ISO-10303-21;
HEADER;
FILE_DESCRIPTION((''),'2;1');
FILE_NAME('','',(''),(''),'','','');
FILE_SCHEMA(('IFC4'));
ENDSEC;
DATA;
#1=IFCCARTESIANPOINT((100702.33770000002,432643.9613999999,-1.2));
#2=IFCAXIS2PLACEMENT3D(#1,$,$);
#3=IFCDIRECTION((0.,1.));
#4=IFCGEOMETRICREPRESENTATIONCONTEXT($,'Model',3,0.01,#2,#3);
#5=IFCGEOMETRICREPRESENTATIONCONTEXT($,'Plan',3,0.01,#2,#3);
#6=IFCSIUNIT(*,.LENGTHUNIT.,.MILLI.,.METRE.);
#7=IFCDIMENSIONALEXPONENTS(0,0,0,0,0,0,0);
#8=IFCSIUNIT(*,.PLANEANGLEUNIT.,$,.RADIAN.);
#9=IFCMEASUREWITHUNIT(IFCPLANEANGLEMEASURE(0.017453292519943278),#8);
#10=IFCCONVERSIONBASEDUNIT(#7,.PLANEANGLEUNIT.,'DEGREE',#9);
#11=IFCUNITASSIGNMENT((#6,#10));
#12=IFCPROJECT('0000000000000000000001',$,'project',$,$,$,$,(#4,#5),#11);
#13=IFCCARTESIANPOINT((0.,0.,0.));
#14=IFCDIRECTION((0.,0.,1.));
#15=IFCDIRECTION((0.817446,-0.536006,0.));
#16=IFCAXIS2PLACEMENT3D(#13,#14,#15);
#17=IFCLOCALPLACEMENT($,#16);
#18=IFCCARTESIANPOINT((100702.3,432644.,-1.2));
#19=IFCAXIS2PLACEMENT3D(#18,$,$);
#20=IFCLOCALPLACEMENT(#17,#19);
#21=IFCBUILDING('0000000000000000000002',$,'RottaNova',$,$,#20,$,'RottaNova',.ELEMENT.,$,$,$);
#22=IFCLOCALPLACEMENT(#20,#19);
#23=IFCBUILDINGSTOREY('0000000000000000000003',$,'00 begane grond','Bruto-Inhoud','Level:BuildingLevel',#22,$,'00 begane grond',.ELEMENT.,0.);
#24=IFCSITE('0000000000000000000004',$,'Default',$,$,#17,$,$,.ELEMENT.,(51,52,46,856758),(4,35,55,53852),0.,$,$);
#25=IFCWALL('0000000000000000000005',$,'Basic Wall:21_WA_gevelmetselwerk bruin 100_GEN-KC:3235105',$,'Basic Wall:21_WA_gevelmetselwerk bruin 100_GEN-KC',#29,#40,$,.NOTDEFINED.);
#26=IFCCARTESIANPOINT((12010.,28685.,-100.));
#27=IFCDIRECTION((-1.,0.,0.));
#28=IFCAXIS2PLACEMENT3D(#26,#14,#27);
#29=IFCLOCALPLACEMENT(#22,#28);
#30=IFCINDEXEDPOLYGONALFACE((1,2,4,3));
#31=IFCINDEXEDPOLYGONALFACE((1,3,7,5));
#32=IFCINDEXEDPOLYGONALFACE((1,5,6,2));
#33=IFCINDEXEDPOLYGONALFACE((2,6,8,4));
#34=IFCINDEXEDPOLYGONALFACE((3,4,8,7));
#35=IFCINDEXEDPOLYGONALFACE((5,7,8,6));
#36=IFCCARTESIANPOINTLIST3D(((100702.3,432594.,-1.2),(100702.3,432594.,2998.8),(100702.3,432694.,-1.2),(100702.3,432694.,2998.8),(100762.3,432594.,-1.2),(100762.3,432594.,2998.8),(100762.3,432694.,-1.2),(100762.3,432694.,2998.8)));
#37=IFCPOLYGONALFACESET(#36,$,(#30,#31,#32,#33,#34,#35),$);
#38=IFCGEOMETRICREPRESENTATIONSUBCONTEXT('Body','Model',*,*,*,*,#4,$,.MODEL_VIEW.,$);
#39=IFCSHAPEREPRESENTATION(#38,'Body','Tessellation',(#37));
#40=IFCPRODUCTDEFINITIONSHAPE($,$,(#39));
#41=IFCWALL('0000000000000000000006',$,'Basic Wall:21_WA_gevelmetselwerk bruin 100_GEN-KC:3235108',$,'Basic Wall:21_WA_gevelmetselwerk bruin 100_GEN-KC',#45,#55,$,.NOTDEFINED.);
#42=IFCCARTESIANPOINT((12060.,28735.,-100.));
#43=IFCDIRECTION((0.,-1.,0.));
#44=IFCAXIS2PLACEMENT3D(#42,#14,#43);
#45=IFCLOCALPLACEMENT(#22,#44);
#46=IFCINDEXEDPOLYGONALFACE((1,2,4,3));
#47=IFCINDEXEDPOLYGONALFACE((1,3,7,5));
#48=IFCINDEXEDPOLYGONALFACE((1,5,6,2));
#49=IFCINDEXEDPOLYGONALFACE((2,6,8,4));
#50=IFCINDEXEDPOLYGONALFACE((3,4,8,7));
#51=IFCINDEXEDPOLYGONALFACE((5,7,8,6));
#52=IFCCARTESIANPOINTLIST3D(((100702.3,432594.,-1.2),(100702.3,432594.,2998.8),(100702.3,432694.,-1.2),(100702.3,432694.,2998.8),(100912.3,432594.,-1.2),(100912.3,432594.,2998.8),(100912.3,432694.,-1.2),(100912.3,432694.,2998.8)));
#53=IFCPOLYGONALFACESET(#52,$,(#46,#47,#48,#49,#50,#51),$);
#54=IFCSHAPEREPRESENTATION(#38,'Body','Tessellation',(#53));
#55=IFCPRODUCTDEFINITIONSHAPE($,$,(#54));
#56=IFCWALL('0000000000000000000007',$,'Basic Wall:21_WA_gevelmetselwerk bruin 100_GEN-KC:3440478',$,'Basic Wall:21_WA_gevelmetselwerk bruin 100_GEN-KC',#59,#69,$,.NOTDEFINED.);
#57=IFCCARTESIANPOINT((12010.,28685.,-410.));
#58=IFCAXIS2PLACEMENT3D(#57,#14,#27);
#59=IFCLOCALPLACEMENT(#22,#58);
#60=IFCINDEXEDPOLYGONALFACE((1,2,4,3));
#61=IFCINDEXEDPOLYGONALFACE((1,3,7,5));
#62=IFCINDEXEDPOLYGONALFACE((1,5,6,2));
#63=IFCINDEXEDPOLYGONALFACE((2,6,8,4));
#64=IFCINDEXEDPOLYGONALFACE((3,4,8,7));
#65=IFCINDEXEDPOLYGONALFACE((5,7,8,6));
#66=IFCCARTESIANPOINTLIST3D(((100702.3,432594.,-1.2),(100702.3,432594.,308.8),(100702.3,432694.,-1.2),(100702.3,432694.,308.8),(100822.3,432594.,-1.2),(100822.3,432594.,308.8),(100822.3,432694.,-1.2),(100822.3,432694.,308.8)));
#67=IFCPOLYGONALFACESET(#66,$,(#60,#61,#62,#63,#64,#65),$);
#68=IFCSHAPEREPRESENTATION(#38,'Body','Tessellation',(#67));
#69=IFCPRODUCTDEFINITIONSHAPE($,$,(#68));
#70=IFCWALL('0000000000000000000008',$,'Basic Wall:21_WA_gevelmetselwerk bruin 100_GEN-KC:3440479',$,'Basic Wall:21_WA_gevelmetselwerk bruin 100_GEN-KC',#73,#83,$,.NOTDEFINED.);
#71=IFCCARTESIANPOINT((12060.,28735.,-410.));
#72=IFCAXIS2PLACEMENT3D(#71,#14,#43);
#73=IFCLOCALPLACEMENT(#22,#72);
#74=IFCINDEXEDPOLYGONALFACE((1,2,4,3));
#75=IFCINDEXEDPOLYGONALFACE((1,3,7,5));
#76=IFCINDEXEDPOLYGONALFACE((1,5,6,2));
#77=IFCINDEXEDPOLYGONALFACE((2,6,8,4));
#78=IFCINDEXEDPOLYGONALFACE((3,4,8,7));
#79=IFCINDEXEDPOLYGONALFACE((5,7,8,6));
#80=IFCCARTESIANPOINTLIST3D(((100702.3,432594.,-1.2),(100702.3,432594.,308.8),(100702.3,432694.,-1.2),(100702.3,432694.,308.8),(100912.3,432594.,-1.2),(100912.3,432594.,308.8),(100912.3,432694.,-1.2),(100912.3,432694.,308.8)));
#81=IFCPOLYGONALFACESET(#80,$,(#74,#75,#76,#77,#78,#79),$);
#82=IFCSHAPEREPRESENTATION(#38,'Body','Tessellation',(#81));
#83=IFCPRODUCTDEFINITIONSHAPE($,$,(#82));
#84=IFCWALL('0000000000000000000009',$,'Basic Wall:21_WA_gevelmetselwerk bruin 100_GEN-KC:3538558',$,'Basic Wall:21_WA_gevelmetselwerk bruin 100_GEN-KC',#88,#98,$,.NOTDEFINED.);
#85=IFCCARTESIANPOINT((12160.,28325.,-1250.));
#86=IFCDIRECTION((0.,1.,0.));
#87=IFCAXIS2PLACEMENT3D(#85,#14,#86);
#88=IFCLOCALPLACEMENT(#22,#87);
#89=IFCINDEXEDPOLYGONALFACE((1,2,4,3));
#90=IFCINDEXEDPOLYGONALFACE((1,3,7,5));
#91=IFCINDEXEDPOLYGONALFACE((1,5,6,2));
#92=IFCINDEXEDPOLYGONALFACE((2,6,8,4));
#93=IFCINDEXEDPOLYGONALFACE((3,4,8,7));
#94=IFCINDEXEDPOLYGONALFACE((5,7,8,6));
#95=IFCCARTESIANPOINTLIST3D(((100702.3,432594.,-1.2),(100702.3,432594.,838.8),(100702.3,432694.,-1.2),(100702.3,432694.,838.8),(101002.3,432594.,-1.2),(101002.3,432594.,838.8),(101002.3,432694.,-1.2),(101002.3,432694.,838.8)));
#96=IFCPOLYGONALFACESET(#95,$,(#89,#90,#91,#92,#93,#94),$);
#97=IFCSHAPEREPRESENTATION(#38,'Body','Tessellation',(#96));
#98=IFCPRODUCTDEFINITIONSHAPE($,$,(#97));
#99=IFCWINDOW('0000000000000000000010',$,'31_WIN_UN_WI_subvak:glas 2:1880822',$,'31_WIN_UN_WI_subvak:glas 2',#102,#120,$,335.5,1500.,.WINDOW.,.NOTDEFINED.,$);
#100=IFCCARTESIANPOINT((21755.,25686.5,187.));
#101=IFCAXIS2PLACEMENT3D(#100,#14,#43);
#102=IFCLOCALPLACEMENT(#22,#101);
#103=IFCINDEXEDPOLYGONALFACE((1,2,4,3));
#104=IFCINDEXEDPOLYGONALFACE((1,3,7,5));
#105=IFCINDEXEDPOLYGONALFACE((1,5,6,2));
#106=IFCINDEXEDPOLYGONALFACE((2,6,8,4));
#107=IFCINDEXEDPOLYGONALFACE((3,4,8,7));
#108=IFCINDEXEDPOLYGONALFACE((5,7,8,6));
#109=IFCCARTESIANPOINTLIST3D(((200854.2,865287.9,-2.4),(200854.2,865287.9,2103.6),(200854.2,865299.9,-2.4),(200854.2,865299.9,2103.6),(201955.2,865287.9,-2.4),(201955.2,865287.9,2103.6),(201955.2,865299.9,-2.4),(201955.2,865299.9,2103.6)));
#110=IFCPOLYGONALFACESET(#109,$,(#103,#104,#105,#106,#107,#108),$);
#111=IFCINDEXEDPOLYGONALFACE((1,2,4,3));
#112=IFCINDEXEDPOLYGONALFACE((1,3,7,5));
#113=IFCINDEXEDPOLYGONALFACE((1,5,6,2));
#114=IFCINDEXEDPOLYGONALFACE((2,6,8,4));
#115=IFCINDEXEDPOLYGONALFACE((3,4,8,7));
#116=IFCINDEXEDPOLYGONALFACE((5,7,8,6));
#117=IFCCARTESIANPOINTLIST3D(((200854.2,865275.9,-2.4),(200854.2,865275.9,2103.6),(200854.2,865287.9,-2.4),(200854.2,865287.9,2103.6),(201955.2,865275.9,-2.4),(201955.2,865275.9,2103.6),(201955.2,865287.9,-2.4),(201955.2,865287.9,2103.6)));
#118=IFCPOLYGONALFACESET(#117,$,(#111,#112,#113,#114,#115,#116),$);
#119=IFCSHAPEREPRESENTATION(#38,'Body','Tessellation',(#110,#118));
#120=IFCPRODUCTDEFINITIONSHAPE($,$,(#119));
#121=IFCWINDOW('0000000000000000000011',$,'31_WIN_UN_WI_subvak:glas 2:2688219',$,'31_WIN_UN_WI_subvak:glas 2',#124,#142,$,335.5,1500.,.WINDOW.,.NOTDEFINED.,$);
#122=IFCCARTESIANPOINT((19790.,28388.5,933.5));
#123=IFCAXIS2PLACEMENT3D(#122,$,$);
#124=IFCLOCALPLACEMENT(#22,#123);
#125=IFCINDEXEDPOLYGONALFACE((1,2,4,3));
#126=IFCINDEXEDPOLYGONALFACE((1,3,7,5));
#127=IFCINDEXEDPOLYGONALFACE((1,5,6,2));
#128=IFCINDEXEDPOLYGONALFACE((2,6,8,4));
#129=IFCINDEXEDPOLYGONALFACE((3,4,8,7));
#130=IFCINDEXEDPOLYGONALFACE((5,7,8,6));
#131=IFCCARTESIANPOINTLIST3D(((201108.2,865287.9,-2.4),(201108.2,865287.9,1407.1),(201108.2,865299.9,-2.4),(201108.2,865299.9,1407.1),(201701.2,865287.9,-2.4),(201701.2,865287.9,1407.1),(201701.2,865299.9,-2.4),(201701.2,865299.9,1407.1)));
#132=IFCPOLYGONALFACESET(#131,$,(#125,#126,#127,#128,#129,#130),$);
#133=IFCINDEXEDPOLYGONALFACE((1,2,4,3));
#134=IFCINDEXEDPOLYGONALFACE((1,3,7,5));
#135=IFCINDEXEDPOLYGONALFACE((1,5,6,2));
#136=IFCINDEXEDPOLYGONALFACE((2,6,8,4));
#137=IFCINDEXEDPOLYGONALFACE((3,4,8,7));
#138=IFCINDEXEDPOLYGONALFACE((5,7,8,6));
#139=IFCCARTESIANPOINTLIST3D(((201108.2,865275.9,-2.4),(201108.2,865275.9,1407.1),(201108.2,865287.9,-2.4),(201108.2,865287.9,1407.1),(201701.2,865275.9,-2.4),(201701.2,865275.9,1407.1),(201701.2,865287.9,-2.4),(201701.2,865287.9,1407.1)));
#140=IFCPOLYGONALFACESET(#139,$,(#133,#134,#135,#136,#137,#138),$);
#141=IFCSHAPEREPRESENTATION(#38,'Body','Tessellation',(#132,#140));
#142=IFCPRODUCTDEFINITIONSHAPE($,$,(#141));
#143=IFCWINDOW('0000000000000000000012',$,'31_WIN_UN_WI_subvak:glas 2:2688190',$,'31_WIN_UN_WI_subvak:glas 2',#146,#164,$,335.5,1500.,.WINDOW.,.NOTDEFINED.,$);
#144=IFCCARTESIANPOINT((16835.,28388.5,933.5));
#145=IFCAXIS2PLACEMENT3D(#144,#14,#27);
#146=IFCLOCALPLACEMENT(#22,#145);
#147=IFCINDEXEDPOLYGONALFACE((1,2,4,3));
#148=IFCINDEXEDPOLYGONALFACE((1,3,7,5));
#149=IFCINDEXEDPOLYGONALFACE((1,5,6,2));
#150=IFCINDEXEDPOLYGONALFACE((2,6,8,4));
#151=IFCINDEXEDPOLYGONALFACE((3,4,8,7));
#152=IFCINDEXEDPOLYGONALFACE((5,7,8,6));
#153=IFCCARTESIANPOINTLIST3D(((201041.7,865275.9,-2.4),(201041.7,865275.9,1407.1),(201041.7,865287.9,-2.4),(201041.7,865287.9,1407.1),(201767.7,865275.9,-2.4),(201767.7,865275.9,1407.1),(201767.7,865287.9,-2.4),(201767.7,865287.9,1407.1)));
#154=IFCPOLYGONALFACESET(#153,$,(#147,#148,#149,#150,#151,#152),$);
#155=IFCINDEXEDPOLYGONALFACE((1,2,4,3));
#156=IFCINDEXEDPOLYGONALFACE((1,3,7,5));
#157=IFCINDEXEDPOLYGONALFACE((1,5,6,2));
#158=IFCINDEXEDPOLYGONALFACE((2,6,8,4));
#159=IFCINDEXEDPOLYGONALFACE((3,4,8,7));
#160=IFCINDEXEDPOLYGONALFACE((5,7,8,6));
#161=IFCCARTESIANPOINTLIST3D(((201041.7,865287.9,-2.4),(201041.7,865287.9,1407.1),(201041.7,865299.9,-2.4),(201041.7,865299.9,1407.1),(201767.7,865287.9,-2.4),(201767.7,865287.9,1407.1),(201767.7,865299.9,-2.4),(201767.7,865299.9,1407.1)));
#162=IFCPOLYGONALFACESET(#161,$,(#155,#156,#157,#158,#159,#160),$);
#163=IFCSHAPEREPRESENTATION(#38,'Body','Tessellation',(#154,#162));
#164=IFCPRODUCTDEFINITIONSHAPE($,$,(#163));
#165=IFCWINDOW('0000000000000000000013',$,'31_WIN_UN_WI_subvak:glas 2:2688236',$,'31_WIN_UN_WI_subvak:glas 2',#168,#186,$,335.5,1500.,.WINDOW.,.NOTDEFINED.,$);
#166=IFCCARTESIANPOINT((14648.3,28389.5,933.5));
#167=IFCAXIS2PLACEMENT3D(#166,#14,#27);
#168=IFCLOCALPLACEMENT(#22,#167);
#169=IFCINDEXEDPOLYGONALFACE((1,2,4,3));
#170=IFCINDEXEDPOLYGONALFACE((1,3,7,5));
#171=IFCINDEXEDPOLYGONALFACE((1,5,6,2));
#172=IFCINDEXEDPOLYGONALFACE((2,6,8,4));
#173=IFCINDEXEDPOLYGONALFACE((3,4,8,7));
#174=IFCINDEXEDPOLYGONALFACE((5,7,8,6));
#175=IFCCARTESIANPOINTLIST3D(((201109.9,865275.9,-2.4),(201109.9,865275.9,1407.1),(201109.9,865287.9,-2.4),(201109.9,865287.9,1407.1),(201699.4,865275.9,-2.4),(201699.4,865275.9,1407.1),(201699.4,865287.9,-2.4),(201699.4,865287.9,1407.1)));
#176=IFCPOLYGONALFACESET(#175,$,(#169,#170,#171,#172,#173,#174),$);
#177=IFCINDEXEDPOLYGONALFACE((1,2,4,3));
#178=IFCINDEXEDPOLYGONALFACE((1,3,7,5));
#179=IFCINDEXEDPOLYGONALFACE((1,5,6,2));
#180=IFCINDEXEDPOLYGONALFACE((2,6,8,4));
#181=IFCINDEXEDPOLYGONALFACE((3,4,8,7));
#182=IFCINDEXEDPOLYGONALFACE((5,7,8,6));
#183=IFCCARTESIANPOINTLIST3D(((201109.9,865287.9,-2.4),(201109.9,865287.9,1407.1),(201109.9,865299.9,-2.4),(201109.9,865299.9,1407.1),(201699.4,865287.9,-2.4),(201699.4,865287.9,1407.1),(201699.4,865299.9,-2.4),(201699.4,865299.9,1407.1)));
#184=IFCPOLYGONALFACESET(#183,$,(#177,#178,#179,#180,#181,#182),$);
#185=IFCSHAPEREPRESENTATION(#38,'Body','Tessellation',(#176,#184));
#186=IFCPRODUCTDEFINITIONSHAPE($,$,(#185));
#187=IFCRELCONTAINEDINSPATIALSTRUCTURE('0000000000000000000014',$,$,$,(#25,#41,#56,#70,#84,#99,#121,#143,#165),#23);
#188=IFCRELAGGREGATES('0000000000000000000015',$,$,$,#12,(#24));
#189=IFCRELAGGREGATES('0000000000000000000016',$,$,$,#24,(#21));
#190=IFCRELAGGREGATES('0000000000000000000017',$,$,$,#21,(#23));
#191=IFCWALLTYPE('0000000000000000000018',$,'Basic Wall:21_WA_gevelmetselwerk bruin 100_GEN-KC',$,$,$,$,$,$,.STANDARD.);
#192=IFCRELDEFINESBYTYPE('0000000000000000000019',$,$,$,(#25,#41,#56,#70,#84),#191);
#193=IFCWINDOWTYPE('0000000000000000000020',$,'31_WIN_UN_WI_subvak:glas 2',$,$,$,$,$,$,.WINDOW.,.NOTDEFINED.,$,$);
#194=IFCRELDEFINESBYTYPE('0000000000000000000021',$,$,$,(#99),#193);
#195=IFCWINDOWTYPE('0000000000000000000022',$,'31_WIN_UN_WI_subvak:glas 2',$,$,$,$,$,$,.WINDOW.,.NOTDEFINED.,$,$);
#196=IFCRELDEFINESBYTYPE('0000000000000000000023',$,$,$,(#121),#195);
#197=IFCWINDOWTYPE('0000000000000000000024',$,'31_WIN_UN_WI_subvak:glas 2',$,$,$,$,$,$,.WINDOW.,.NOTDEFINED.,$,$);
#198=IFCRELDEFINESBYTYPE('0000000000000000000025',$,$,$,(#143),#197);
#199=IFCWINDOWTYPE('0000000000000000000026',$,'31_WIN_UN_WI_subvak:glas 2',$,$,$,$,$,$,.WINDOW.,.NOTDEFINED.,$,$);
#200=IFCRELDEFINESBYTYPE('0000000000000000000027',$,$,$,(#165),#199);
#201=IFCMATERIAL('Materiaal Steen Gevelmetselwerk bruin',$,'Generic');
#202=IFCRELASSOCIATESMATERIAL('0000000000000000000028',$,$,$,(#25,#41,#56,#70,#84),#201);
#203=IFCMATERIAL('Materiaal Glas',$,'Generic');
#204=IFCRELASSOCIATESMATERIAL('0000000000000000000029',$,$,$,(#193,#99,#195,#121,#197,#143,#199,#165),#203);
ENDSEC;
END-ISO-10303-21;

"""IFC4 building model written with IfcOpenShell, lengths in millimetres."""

from ifc_helpers import new_model, entity, si_unit, converted_unit, direction, frame, place, context, subcontext, project, spatial, indexed_curve, outline, extrude, source, transform, mapped, material, type_object, type_shapes, element, save


model = new_model("IFC4")

# Units and contexts
model_context = context("Model", 3, precision=0.01, world=frame((100702.33770000002, 432643.9613999999, -1.2)), true_north=direction((0.0, 1.0)))
plan_context = context("Plan", 3, precision=0.01, world=frame((100702.33770000002, 432643.9613999999, -1.2)), true_north=direction((0.0, 1.0)))
body_context = subcontext(model_context, "Body", "Model", "MODEL_VIEW")
ifc_project = project(units=[si_unit("LENGTHUNIT", "METRE", prefix="MILLI"), converted_unit("PLANEANGLEUNIT", "DEGREE", entity("IfcPlaneAngleMeasure", 0.017453292519943278), si_unit("PLANEANGLEUNIT", "RADIAN"), dimensions=[0, 0, 0, 0, 0, 0, 0])], contexts=[model_context, plan_context])

# Site, building, storey
site_placement = place(None, frame((0.0, 0.0, 0.0), z_axis=(0.0, 0.0, 1.0), x_axis=(0.817446, -0.536006, 0.0)))
site = spatial("IfcSite", under=ifc_project, at=site_placement, Name="Default", CompositionType="ELEMENT", RefLatitude=(51, 52, 46, 856758), RefLongitude=(4, 35, 55, 53852), RefElevation=0.0)
building_placement = place(site_placement, frame((100702.3, 432644.0, -1.2)))
building = spatial("IfcBuilding", under=site, at=building_placement, Name="RottaNova", LongName="RottaNova", CompositionType="ELEMENT")
storey_placement = place(building_placement, frame((100702.3, 432644.0, -1.2)))
storey = spatial("IfcBuildingStorey", under=building, at=storey_placement, Name="00 begane grond", Description="Bruto-Inhoud", ObjectType="Level:BuildingLevel", LongName="00 begane grond", CompositionType="ELEMENT", Elevation=0.0)

# Walls
ifc_material_1 = material(Name="Materiaal Steen Gevelmetselwerk bruin", Category="Generic")
wall_type_1 = type_object("IfcWallType", Name="Basic Wall:21_WA_gevelmetselwerk bruin 100_GEN-KC", PredefinedType="STANDARD")
wall_1_placement = place(storey_placement, frame((12010.0, 28685.0, -100.0), z_axis=(0.0, 0.0, 1.0), x_axis=(-1.0, 0.0, 0.0)))
element("IfcWall", 1, at=wall_1_placement, inside=storey, type_object=wall_type_1, material=ifc_material_1, Name="Basic Wall:21_WA_gevelmetselwerk bruin 100_GEN-KC:3235105", ObjectType="Basic Wall:21_WA_gevelmetselwerk bruin 100_GEN-KC", PredefinedType="NOTDEFINED", context=body_context, shape_type="SweptSolid", body=[
    extrude(outline(indexed_curve([(60.0, 50.0), (0.0, 50.0), (0.0, -50.0), (60.0, -50.0), (60.0, 50.0)], self_intersect=False)), frame((100702.3, 432644.0, -1.2)), (0.0, 0.0, 1.0), 3000.0),
])
wall_2_placement = place(storey_placement, frame((12060.0, 28735.0, -100.0), z_axis=(0.0, 0.0, 1.0), x_axis=(0.0, -1.0, 0.0)))
element("IfcWall", 2, at=wall_2_placement, inside=storey, type_object=wall_type_1, material=ifc_material_1, Name="Basic Wall:21_WA_gevelmetselwerk bruin 100_GEN-KC:3235108", ObjectType="Basic Wall:21_WA_gevelmetselwerk bruin 100_GEN-KC", PredefinedType="NOTDEFINED", context=body_context, shape_type="SweptSolid", body=[
    extrude(outline(indexed_curve([(210.0, 50.0), (0.0, 50.0), (0.0, -50.0), (210.0, -50.0), (210.0, 50.0)], self_intersect=False)), frame((100702.3, 432644.0, -1.2)), (0.0, 0.0, 1.0), 3000.0),
])
wall_3_placement = place(storey_placement, frame((12010.0, 28685.0, -410.0), z_axis=(0.0, 0.0, 1.0), x_axis=(-1.0, 0.0, 0.0)))
element("IfcWall", 3, at=wall_3_placement, inside=storey, type_object=wall_type_1, material=ifc_material_1, Name="Basic Wall:21_WA_gevelmetselwerk bruin 100_GEN-KC:3440478", ObjectType="Basic Wall:21_WA_gevelmetselwerk bruin 100_GEN-KC", PredefinedType="NOTDEFINED", context=body_context, shape_type="SweptSolid", body=[
    extrude(outline(indexed_curve([(120.0, 50.0), (0.0, 50.0), (0.0, -50.0), (120.0, -50.0), (120.0, 50.0)], self_intersect=False)), frame((100702.3, 432644.0, -1.2)), (0.0, 0.0, 1.0), 310.0),
])
wall_4_placement = place(storey_placement, frame((12060.0, 28735.0, -410.0), z_axis=(0.0, 0.0, 1.0), x_axis=(0.0, -1.0, 0.0)))
element("IfcWall", 4, at=wall_4_placement, inside=storey, type_object=wall_type_1, material=ifc_material_1, Name="Basic Wall:21_WA_gevelmetselwerk bruin 100_GEN-KC:3440479", ObjectType="Basic Wall:21_WA_gevelmetselwerk bruin 100_GEN-KC", PredefinedType="NOTDEFINED", context=body_context, shape_type="SweptSolid", body=[
    extrude(outline(indexed_curve([(210.0, 50.0), (0.0, 50.0), (0.0, -50.0), (210.0, -50.0), (210.0, 50.0)], self_intersect=False)), frame((100702.3, 432644.0, -1.2)), (0.0, 0.0, 1.0), 310.0),
])
wall_5_placement = place(storey_placement, frame((12160.0, 28325.0, -1250.0), z_axis=(0.0, 0.0, 1.0), x_axis=(0.0, 1.0, 0.0)))
element("IfcWall", 5, at=wall_5_placement, inside=storey, type_object=wall_type_1, material=ifc_material_1, Name="Basic Wall:21_WA_gevelmetselwerk bruin 100_GEN-KC:3538558", ObjectType="Basic Wall:21_WA_gevelmetselwerk bruin 100_GEN-KC", PredefinedType="NOTDEFINED", context=body_context, shape_type="SweptSolid", body=[
    extrude(outline(indexed_curve([(300.0, 50.0), (0.0, 50.0), (0.0, -50.0), (300.0, -50.0), (300.0, 50.0)], self_intersect=False)), frame((100702.3, 432644.0, -1.2)), (0.0, 0.0, 1.0), 840.0),
])

# Windows
ifc_material_2 = material(Name="Materiaal Glas", Category="Generic")
window_type_1 = type_object("IfcWindowType", Name="31_WIN_UN_WI_subvak:glas 2", PartitioningType="NOTDEFINED", PredefinedType="WINDOW", material=ifc_material_2)
shared_shape_1 = source(frame((100702.3, 432644.0, -1.2)), body_context, "Body", "SweptSolid", [
    extrude(outline(indexed_curve([(-6.0, -550.5), (6.0, -550.5), (6.0, 550.5), (-6.0, 550.5), (-6.0, -550.5)], self_intersect=False)), frame((0.0, 6.0, 0.0), z_axis=(0.0, 0.0, 1.0), x_axis=(0.0, -1.0, 0.0)), (0.0, 0.0, 1.0), 2106.0),
    extrude(outline(indexed_curve([(-6.0, -550.5), (6.0, -550.5), (6.0, 550.5), (-6.0, 550.5), (-6.0, -550.5)], self_intersect=False)), frame((0.0, -6.0, 0.0), z_axis=(0.0, 0.0, 1.0), x_axis=(0.0, -1.0, 0.0)), (0.0, 0.0, 1.0), 2106.0),
])
type_shapes(window_type_1, [shared_shape_1])
window_1_placement = place(storey_placement, frame((21755.0, 25686.5, 187.0), z_axis=(0.0, 0.0, 1.0), x_axis=(0.0, -1.0, 0.0)))
element("IfcWindow", 6, at=window_1_placement, inside=storey, type_object=window_type_1, material=ifc_material_2, Name="31_WIN_UN_WI_subvak:glas 2:1880822", ObjectType="31_WIN_UN_WI_subvak:glas 2", OverallHeight=335.5, OverallWidth=1500.0, PartitioningType="NOTDEFINED", PredefinedType="WINDOW", context=body_context, shape_type="MappedRepresentation", body=[
    mapped(shared_shape_1, transform((100702.3, 432644.0, -1.2), scale=1.0)),
])
window_type_2 = type_object("IfcWindowType", Name="31_WIN_UN_WI_subvak:glas 2", PartitioningType="NOTDEFINED", PredefinedType="WINDOW", material=ifc_material_2)
shared_shape_2 = source(frame((100702.3, 432644.0, -1.2)), body_context, "Body", "SweptSolid", [
    extrude(outline(indexed_curve([(-6.0, -296.5), (6.0, -296.5), (6.0, 296.5), (-6.0, 296.5), (-6.0, -296.5)], self_intersect=False)), frame((0.0, 6.0, 0.0), z_axis=(0.0, 0.0, 1.0), x_axis=(0.0, -1.0, 0.0)), (0.0, 0.0, 1.0), 1409.5),
    extrude(outline(indexed_curve([(-6.0, -296.5), (6.0, -296.5), (6.0, 296.5), (-6.0, 296.5), (-6.0, -296.5)], self_intersect=False)), frame((0.0, -6.0, 0.0), z_axis=(0.0, 0.0, 1.0), x_axis=(0.0, -1.0, 0.0)), (0.0, 0.0, 1.0), 1409.5),
])
type_shapes(window_type_2, [shared_shape_2])
window_2_placement = place(storey_placement, frame((19790.0, 28388.5, 933.5)))
element("IfcWindow", 7, at=window_2_placement, inside=storey, type_object=window_type_2, material=ifc_material_2, Name="31_WIN_UN_WI_subvak:glas 2:2688219", ObjectType="31_WIN_UN_WI_subvak:glas 2", OverallHeight=335.5, OverallWidth=1500.0, PartitioningType="NOTDEFINED", PredefinedType="WINDOW", context=body_context, shape_type="MappedRepresentation", body=[
    mapped(shared_shape_2, transform((100702.3, 432644.0, -1.2), scale=1.0)),
])
window_type_3 = type_object("IfcWindowType", Name="31_WIN_UN_WI_subvak:glas 2", PartitioningType="NOTDEFINED", PredefinedType="WINDOW", material=ifc_material_2)
shared_shape_3 = source(frame((100702.3, 432644.0, -1.2)), body_context, "Body", "SweptSolid", [
    extrude(outline(indexed_curve([(-363.0, -6.0), (363.0, -6.0), (363.0, 6.0), (-363.0, 6.0), (-363.0, -6.0)], self_intersect=False)), frame((0.0, -6.0, 0.0)), (0.0, 0.0, 1.0), 1409.5),
    extrude(outline(indexed_curve([(-363.0, -6.0), (363.0, -6.0), (363.0, 6.0), (-363.0, 6.0), (-363.0, -6.0)], self_intersect=False)), frame((0.0, 6.0, 0.0)), (0.0, 0.0, 1.0), 1409.5),
])
type_shapes(window_type_3, [shared_shape_3])
window_3_placement = place(storey_placement, frame((16835.0, 28388.5, 933.5), z_axis=(0.0, 0.0, 1.0), x_axis=(-1.0, 0.0, 0.0)))
element("IfcWindow", 8, at=window_3_placement, inside=storey, type_object=window_type_3, material=ifc_material_2, Name="31_WIN_UN_WI_subvak:glas 2:2688190", ObjectType="31_WIN_UN_WI_subvak:glas 2", OverallHeight=335.5, OverallWidth=1500.0, PartitioningType="NOTDEFINED", PredefinedType="WINDOW", context=body_context, shape_type="MappedRepresentation", body=[
    mapped(shared_shape_3, transform((100702.3, 432644.0, -1.2), scale=1.0)),
])
window_type_4 = type_object("IfcWindowType", Name="31_WIN_UN_WI_subvak:glas 2", PartitioningType="NOTDEFINED", PredefinedType="WINDOW", material=ifc_material_2)
shared_shape_4 = source(frame((100702.3, 432644.0, -1.2)), body_context, "Body", "SweptSolid", [
    extrude(outline(indexed_curve([(-294.7, -6.0), (294.7, -6.0), (294.7, 6.0), (-294.7, 6.0), (-294.7, -6.0)], self_intersect=False)), frame((0.0, -6.0, 0.0)), (0.0, 0.0, 1.0), 1409.5),
    extrude(outline(indexed_curve([(-294.8, -6.0), (294.8, -6.0), (294.8, 6.0), (-294.8, 6.0), (-294.8, -6.0)], self_intersect=False)), frame((0.0, 6.0, 0.0)), (0.0, 0.0, 1.0), 1409.5),
])
type_shapes(window_type_4, [shared_shape_4])
for number, where, z_axis, x_axis, name in (
    (9, (14648.3, 28389.5, 933.5), (0.0, 0.0, 1.0), (-1.0, 0.0, 0.0), "31_WIN_UN_WI_subvak:glas 2:2688236"),
):
    element("IfcWindow", number, at=place(storey_placement, frame(where, z_axis=z_axis, x_axis=x_axis)), inside=storey, type_object=window_type_4, material=ifc_material_2, Name=name, ObjectType="31_WIN_UN_WI_subvak:glas 2", OverallHeight=335.5, OverallWidth=1500.0, PartitioningType="NOTDEFINED", PredefinedType="WINDOW", context=body_context, shape_type="MappedRepresentation", body=[
        mapped(shared_shape_4, transform((100702.3, 432644.0, -1.2), scale=1.0)),
    ])

save(model, "model.ifc")
